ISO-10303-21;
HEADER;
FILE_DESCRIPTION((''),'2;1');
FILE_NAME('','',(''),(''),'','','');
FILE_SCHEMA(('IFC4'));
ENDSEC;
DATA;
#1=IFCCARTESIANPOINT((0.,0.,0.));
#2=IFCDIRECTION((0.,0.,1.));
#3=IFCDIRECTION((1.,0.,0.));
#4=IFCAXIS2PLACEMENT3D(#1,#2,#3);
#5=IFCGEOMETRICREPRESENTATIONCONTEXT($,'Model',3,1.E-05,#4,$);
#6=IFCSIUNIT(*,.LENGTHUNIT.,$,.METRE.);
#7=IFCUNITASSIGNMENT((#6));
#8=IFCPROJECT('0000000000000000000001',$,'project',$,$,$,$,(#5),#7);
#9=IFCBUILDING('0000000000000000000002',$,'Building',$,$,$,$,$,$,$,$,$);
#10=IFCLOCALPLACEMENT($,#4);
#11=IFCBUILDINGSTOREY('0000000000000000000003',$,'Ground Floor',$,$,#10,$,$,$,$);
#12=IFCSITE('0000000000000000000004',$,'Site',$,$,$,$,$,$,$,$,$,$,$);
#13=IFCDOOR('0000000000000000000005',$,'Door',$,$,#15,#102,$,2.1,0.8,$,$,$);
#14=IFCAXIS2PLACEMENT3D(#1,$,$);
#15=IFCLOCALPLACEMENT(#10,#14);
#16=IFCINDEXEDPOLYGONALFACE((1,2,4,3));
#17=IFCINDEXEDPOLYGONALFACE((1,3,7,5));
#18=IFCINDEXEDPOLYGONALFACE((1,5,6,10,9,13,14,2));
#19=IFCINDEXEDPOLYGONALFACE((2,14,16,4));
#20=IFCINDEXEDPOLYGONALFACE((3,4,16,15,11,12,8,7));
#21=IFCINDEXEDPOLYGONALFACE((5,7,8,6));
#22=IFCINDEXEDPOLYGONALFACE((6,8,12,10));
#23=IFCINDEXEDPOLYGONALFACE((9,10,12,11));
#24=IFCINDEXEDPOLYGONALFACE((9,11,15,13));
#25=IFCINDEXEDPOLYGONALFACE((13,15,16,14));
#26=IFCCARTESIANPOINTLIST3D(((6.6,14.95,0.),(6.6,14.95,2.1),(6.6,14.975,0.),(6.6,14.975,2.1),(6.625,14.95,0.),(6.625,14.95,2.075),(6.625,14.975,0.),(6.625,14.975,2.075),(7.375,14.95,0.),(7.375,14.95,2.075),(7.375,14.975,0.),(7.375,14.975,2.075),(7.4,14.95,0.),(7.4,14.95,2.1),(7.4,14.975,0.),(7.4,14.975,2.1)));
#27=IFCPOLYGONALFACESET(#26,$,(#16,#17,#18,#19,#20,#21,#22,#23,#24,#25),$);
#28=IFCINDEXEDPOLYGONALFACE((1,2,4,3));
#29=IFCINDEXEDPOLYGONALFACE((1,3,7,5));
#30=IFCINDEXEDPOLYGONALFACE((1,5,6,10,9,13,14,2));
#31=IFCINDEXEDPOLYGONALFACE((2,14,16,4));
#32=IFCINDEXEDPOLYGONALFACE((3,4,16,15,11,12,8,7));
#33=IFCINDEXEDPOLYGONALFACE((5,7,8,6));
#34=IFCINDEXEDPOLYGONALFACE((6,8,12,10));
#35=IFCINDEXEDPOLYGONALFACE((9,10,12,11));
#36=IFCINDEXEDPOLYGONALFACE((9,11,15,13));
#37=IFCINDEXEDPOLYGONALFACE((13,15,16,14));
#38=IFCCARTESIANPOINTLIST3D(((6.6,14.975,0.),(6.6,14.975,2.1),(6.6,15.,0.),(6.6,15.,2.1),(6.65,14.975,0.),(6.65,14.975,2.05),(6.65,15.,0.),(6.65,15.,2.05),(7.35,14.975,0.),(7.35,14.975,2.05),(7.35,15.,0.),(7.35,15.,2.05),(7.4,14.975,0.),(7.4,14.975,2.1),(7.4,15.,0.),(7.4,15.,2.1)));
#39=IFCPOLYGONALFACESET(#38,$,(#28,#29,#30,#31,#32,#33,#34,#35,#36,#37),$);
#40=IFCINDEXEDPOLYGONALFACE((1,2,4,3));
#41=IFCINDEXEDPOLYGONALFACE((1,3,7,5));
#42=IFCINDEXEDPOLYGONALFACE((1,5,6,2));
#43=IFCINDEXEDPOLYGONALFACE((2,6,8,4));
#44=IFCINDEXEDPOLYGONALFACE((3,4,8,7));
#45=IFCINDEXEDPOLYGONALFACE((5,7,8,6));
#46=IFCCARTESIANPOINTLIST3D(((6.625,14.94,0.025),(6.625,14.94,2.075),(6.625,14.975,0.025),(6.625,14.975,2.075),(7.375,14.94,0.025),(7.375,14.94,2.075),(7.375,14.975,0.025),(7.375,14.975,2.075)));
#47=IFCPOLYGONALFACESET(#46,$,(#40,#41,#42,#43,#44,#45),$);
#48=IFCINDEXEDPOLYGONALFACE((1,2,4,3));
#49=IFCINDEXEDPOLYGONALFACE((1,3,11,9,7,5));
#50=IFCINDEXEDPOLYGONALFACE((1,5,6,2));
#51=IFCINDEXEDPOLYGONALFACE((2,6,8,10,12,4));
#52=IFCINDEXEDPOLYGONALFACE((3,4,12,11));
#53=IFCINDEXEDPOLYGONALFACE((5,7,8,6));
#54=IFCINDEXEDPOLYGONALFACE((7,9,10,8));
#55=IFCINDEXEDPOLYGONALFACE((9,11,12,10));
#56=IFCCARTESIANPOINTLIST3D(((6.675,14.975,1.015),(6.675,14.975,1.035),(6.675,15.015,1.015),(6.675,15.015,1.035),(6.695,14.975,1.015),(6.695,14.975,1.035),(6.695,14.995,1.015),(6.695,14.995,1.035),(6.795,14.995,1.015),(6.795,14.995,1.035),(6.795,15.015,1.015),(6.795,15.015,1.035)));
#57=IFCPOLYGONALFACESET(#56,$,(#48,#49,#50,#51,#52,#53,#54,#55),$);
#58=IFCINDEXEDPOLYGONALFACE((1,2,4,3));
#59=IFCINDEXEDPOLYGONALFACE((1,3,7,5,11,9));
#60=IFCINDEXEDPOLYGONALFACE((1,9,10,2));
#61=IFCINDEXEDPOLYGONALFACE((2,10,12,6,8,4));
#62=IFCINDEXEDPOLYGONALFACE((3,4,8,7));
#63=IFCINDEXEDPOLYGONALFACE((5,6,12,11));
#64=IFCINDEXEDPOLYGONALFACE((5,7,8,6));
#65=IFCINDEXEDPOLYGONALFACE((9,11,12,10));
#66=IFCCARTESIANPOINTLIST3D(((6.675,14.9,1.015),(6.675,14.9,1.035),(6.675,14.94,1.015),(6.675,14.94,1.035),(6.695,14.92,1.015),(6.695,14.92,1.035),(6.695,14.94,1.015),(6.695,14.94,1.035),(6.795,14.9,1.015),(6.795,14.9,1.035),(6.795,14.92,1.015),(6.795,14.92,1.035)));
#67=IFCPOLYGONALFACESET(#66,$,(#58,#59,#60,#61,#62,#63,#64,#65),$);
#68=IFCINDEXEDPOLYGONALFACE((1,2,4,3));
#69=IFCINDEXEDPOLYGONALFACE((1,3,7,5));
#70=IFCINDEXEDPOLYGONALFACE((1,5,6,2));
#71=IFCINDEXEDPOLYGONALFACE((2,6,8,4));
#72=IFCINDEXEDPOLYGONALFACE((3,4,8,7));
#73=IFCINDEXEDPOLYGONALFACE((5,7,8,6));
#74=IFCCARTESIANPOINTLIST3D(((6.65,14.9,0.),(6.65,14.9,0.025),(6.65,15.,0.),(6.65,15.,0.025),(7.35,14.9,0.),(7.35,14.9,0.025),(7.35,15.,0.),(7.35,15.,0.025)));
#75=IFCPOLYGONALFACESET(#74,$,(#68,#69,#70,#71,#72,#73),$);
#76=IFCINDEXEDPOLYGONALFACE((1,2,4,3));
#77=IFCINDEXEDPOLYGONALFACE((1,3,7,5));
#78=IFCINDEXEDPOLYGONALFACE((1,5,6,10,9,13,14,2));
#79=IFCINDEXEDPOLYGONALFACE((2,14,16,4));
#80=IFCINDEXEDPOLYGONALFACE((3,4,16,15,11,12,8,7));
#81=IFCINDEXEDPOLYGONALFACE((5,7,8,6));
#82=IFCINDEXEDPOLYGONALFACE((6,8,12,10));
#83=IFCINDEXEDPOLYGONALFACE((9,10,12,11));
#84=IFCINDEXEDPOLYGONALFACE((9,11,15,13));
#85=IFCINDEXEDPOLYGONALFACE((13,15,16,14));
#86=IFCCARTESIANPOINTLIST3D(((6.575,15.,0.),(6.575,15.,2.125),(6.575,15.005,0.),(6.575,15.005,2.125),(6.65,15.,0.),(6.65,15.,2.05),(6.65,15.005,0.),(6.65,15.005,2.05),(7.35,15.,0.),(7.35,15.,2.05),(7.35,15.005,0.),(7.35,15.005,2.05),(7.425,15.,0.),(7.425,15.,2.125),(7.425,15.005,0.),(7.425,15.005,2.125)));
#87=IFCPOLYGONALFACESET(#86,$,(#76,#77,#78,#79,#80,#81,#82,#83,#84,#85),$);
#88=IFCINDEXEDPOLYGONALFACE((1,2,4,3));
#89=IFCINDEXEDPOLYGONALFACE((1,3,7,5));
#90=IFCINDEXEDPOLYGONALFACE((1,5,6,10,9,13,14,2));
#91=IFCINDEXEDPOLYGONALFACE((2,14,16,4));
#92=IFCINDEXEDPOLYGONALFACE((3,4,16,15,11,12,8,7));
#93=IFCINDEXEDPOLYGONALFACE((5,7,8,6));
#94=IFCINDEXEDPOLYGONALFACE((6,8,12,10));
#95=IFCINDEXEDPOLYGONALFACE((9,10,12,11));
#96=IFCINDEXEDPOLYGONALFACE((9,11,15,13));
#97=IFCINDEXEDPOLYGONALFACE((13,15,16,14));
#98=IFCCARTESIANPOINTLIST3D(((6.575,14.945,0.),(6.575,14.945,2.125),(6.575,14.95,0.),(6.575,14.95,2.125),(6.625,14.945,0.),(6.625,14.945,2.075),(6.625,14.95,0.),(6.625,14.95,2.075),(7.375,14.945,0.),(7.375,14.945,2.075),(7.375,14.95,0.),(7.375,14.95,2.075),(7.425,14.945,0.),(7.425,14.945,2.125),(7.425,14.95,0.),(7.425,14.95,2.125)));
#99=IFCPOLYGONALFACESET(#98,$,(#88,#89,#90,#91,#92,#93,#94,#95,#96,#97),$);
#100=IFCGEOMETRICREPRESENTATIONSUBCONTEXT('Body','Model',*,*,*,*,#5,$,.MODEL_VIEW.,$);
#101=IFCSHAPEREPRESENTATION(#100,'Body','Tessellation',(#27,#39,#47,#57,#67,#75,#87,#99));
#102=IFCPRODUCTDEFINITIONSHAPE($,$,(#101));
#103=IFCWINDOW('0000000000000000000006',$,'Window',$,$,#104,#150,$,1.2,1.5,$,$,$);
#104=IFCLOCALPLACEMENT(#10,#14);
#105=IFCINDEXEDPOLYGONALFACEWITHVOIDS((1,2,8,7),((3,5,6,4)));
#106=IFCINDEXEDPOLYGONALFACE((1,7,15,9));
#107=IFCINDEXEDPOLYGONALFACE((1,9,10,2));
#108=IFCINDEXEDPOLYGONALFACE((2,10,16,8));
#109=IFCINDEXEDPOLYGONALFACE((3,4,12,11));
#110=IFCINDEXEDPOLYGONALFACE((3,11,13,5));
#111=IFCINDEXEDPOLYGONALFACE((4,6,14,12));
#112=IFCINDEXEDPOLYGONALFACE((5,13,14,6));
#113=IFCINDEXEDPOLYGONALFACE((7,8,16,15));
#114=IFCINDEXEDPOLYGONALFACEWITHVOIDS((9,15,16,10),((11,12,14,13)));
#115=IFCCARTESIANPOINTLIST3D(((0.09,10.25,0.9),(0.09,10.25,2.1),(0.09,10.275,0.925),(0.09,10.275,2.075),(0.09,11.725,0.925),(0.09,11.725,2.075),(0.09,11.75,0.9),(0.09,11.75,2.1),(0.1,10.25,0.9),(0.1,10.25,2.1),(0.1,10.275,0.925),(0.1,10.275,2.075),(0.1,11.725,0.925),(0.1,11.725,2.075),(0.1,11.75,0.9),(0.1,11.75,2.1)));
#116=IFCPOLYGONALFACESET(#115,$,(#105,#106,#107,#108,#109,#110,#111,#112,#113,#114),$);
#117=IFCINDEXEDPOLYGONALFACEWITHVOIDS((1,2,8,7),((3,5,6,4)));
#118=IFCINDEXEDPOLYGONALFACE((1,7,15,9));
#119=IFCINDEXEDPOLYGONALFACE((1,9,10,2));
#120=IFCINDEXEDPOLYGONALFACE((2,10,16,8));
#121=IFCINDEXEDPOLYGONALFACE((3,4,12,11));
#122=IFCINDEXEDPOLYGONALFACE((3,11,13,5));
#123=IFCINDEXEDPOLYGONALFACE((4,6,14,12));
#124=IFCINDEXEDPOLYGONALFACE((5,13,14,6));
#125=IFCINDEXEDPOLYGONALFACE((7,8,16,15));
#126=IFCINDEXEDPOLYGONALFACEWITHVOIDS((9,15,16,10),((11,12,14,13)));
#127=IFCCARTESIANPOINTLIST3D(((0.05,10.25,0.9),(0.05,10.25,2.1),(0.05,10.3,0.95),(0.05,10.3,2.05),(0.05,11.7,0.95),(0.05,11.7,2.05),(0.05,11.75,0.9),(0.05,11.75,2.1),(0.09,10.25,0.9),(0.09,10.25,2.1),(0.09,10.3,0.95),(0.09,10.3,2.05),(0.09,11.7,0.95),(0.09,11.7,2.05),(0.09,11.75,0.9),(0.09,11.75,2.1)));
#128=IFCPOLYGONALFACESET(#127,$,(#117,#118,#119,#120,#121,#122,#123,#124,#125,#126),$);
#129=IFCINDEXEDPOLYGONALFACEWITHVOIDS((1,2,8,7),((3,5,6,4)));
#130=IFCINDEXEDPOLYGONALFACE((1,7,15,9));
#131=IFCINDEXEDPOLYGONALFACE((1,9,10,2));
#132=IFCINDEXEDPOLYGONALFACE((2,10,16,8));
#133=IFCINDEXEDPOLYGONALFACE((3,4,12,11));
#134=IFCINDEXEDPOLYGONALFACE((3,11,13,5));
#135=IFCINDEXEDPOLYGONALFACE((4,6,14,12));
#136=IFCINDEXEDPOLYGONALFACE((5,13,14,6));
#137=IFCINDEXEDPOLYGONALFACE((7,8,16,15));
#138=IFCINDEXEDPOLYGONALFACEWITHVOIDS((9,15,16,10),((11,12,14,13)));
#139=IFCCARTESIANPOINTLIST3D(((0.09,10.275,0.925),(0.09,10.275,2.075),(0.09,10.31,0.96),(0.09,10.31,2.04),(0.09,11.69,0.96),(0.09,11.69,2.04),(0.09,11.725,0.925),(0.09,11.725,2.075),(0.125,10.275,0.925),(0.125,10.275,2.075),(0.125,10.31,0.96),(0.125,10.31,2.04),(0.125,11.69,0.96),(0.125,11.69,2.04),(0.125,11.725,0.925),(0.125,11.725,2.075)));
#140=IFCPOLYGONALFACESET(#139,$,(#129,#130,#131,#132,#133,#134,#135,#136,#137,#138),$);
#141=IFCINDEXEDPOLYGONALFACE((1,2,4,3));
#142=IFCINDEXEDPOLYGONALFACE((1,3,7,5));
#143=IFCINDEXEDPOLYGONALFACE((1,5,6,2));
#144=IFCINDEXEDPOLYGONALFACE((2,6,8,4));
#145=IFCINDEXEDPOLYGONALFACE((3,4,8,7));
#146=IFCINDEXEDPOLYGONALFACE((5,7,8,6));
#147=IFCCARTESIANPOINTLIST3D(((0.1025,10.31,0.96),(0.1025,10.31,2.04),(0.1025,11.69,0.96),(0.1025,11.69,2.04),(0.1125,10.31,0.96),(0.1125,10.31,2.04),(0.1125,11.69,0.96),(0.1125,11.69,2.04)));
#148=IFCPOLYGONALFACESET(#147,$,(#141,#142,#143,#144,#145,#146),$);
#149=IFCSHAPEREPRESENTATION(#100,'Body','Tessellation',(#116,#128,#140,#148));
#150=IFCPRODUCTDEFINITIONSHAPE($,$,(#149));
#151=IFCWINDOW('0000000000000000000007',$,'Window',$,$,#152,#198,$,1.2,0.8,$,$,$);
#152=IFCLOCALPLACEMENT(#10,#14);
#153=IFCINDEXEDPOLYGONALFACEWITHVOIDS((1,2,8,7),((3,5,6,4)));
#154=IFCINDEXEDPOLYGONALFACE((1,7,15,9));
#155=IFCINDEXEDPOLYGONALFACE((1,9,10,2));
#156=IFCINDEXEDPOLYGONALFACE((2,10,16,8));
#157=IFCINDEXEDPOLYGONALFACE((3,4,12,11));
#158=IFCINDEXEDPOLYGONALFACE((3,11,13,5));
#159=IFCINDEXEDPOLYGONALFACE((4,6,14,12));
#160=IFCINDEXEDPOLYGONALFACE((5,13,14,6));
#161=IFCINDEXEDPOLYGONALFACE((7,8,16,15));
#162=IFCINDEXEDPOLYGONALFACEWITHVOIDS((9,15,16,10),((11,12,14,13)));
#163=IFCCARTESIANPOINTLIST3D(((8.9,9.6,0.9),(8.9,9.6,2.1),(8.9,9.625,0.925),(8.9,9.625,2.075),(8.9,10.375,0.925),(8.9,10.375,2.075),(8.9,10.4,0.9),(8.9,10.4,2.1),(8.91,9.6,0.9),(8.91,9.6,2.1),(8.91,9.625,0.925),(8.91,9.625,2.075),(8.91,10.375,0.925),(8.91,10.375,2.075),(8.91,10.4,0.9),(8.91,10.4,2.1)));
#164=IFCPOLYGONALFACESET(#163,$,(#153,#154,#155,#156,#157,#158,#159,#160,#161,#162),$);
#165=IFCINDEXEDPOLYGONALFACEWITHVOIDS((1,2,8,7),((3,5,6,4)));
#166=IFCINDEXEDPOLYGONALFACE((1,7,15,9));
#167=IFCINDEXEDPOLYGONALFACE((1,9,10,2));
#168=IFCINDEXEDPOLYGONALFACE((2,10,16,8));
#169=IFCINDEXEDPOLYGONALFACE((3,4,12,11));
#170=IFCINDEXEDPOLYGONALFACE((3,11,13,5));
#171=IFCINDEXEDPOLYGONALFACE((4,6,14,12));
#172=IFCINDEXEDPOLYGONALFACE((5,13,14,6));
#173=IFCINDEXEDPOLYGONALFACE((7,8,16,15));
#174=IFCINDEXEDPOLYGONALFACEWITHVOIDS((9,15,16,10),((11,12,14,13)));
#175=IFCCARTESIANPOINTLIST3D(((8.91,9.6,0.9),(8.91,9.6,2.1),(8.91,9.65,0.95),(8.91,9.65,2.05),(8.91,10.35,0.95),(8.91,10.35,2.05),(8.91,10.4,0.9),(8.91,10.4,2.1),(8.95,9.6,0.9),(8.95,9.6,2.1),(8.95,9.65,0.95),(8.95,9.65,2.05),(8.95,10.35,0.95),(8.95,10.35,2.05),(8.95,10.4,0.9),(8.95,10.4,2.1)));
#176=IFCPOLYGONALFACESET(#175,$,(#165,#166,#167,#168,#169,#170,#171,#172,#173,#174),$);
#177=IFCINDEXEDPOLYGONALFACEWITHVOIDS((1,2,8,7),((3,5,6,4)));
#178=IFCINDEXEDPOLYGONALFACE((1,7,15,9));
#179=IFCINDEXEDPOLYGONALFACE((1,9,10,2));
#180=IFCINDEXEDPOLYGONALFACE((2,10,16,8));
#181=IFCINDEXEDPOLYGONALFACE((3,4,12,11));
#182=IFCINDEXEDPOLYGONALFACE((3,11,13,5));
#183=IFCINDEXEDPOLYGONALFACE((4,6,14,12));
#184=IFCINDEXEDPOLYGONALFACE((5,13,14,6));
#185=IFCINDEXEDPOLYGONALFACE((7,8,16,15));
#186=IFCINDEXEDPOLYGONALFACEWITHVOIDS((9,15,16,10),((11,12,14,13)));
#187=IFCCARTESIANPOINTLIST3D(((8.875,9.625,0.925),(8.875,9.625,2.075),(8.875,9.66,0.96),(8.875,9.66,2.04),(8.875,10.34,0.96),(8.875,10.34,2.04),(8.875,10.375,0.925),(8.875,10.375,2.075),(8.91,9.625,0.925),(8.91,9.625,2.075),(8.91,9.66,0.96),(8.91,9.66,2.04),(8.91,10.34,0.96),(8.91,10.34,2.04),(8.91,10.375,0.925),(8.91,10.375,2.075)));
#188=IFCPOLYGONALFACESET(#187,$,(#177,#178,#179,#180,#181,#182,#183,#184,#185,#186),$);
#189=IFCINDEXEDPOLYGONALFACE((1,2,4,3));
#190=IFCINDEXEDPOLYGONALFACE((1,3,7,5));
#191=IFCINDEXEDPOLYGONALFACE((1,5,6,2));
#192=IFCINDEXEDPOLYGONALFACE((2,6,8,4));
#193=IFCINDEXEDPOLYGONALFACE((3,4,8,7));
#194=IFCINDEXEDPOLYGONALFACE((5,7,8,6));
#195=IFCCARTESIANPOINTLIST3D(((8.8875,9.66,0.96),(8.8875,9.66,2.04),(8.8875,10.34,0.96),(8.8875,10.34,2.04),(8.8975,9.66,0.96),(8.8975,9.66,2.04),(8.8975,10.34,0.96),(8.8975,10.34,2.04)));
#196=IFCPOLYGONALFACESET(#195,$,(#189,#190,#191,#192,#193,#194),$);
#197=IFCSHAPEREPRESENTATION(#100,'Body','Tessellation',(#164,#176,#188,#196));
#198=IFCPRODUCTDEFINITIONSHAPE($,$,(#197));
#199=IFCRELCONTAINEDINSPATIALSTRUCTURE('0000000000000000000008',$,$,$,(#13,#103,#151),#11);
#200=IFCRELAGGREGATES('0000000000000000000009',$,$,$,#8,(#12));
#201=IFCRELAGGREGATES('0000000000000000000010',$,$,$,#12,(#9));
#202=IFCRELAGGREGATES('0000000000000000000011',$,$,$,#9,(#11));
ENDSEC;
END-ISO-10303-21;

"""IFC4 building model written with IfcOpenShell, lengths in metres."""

from ifc_helpers import new_model, si_unit, frame, origin_with_axes, place, context, subcontext, project, spatial, line, indexed_curve, outline, extrude, element, save


model = new_model("IFC4")

# Units and contexts
model_context = context("Model", 3, precision=1e-05, world=origin_with_axes())
body_context = subcontext(model_context, "Body", "Model", "MODEL_VIEW")
ifc_project = project(units=[si_unit("LENGTHUNIT", "METRE")], contexts=[model_context])

# Site, building, storey
site = spatial("IfcSite", under=ifc_project, Name="Site")
building = spatial("IfcBuilding", under=site, Name="Building")
storey_placement = place(None, origin_with_axes())
storey = spatial("IfcBuildingStorey", under=building, at=storey_placement, Name="Ground Floor")

# Door
door_1_placement = place(storey_placement, frame((7.4, 15.0, 0.0), z_axis=(0.0, 0.0, 1.0), x_axis=(-1.0, 0.0, 0.0)))
element("IfcDoor", 1, at=door_1_placement, inside=storey, Name="Door", OverallHeight=2.1, OverallWidth=0.8, context=body_context, shape_type="SweptSolid", body=[
    extrude(outline(indexed_curve([(0.0, 0.0), (0.0, 2.1), (0.8, 2.1), (0.8, 0.0), (0.775, 0.0), (0.775, 2.075), (0.025, 2.075), (0.025, 0.0)], segments=[line(1, 2, 3, 4, 5, 6, 7, 8, 1)])), frame((0.0, 0.025, 0.0), z_axis=(0.0, -1.0, 0.0), x_axis=(1.0, 0.0, 0.0)), (0.0, 0.0, -1.0), 0.025),
    extrude(outline(indexed_curve([(0.0, 0.0), (0.0, 2.1), (0.8, 2.1), (0.8, 0.0), (0.75, 0.0), (0.75, 2.05), (0.05, 2.05), (0.05, 0.0)], segments=[line(1, 2, 3, 4, 5, 6, 7, 8, 1)])), frame((0.0, 0.0, 0.0), z_axis=(0.0, -1.0, 0.0), x_axis=(1.0, 0.0, 0.0)), (0.0, 0.0, -1.0), 0.025),
    extrude(outline(indexed_curve([(0.0, 0.0), (0.75, 0.0), (0.75, 0.035), (0.0, 0.035)], segments=[line(1, 2, 3, 4, 1)])), frame((0.025, 0.025, 0.025), z_axis=(0.0, 0.0, 1.0), x_axis=(1.0, 0.0, 0.0)), (0.0, 0.0, 1.0), 2.05),
    extrude(outline(indexed_curve([(0.0, 0.0), (0.0, -0.04), (-0.12, -0.04), (-0.12, -0.02), (-0.02, -0.02), (-0.02, 0.0)], segments=[line(1, 2, 3, 4, 5, 6, 1)])), frame((0.725, 0.025, 1.015), z_axis=(0.0, 0.0, 1.0), x_axis=(1.0, 0.0, 0.0)), (0.0, 0.0, 1.0), 0.02),
    extrude(outline(indexed_curve([(0.0, 0.0), (0.0, 0.04), (-0.12, 0.04), (-0.12, 0.02), (-0.02, 0.02), (-0.02, 0.0)], segments=[line(1, 2, 3, 4, 5, 6, 1)])), frame((0.725, 0.06, 1.015), z_axis=(0.0, 0.0, 1.0), x_axis=(1.0, 0.0, 0.0)), (0.0, 0.0, 1.0), 0.02),
    extrude(outline(indexed_curve([(0.0, 0.0), (0.7, 0.0), (0.7, 0.1), (0.0, 0.1)], segments=[line(1, 2, 3, 4, 1)])), frame((0.05, 0.0, 0.0), z_axis=(0.0, 0.0, 1.0), x_axis=(1.0, 0.0, 0.0)), (0.0, 0.0, 1.0), 0.025),
    extrude(outline(indexed_curve([(0.0, 0.0), (0.0, 2.125), (0.85, 2.125), (0.85, 0.0), (0.775, 0.0), (0.775, 2.05), (0.075, 2.05), (0.075, 0.0)], segments=[line(1, 2, 3, 4, 5, 6, 7, 8, 1)])), frame((-0.025, -0.005, 0.0), z_axis=(0.0, -1.0, 0.0), x_axis=(1.0, 0.0, 0.0)), (0.0, 0.0, -1.0), 0.005),
    extrude(outline(indexed_curve([(0.0, 0.0), (0.0, 2.125), (0.85, 2.125), (0.85, 0.0), (0.8, 0.0), (0.8, 2.075), (0.05, 2.075), (0.05, 0.0)], segments=[line(1, 2, 3, 4, 5, 6, 7, 8, 1)])), frame((-0.025, 0.05, 0.0), z_axis=(0.0, -1.0, 0.0), x_axis=(1.0, 0.0, 0.0)), (0.0, 0.0, -1.0), 0.005),
])

# Windows
window_1_placement = place(storey_placement, frame((0.0, 11.75, 0.9), z_axis=(0.0, 0.0, 1.0), x_axis=(0.0, -1.0, 0.0)))
element("IfcWindow", 2, at=window_1_placement, inside=storey, Name="Window", OverallHeight=1.2, OverallWidth=1.5, context=body_context, shape_type="SweptSolid", body=[
    extrude(outline(indexed_curve([(0.0, 0.0), (1.5, 0.0), (1.5, 1.2), (0.0, 1.2)], segments=[line(1, 2, 3, 4, 1)]), holes=[indexed_curve([(0.025, 0.025), (1.475, 0.025), (1.475, 1.175), (0.025, 1.175)], segments=[line(1, 2, 3, 4, 1)])]), frame((0.0, 0.09, 0.0), z_axis=(0.0, -1.0, 0.0), x_axis=(1.0, 0.0, 0.0)), (0.0, 0.0, -1.0), 0.01),
    extrude(outline(indexed_curve([(0.0, 0.0), (1.5, 0.0), (1.5, 1.2), (0.0, 1.2)], segments=[line(1, 2, 3, 4, 1)]), holes=[indexed_curve([(0.05, 0.05), (1.45, 0.05), (1.45, 1.15), (0.05, 1.15)], segments=[line(1, 2, 3, 4, 1)])]), frame((0.0, 0.05, 0.0), z_axis=(0.0, -1.0, 0.0), x_axis=(1.0, 0.0, 0.0)), (0.0, 0.0, -1.0), 0.04),
    extrude(outline(indexed_curve([(0.0, 0.0), (1.45, 0.0), (1.45, 1.15), (0.0, 1.15)], segments=[line(1, 2, 3, 4, 1)]), holes=[indexed_curve([(0.035, 0.035), (1.415, 0.035), (1.415, 1.115), (0.035, 1.115)], segments=[line(1, 2, 3, 4, 1)])]), frame((0.025, 0.09, 0.025), z_axis=(0.0, -1.0, 0.0), x_axis=(1.0, 0.0, 0.0)), (0.0, 0.0, -1.0), 0.035),
    extrude(outline(indexed_curve([(0.035, 0.035), (1.415, 0.035), (1.415, 1.115), (0.035, 1.115)], segments=[line(1, 2, 3, 4, 1)])), frame((0.025, 0.1025, 0.025), z_axis=(0.0, -1.0, 0.0), x_axis=(1.0, 0.0, 0.0)), (0.0, 0.0, -1.0), 0.01),
])
window_2_placement = place(storey_placement, frame((9.0, 9.6, 0.9), z_axis=(0.0, 0.0, 1.0), x_axis=(0.0, 1.0, 0.0)))
element("IfcWindow", 3, at=window_2_placement, inside=storey, Name="Window", OverallHeight=1.2, OverallWidth=0.8, context=body_context, shape_type="SweptSolid", body=[
    extrude(outline(indexed_curve([(0.0, 0.0), (0.8, 0.0), (0.8, 1.2), (0.0, 1.2)], segments=[line(1, 2, 3, 4, 1)]), holes=[indexed_curve([(0.025, 0.025), (0.775, 0.025), (0.775, 1.175), (0.025, 1.175)], segments=[line(1, 2, 3, 4, 1)])]), frame((0.0, 0.09, 0.0), z_axis=(0.0, -1.0, 0.0), x_axis=(1.0, 0.0, 0.0)), (0.0, 0.0, -1.0), 0.01),
    extrude(outline(indexed_curve([(0.0, 0.0), (0.8, 0.0), (0.8, 1.2), (0.0, 1.2)], segments=[line(1, 2, 3, 4, 1)]), holes=[indexed_curve([(0.05, 0.05), (0.75, 0.05), (0.75, 1.15), (0.05, 1.15)], segments=[line(1, 2, 3, 4, 1)])]), frame((0.0, 0.05, 0.0), z_axis=(0.0, -1.0, 0.0), x_axis=(1.0, 0.0, 0.0)), (0.0, 0.0, -1.0), 0.04),
    extrude(outline(indexed_curve([(0.0, 0.0), (0.75, 0.0), (0.75, 1.15), (0.0, 1.15)], segments=[line(1, 2, 3, 4, 1)]), holes=[indexed_curve([(0.035, 0.035), (0.715, 0.035), (0.715, 1.115), (0.035, 1.115)], segments=[line(1, 2, 3, 4, 1)])]), frame((0.025, 0.09, 0.025), z_axis=(0.0, -1.0, 0.0), x_axis=(1.0, 0.0, 0.0)), (0.0, 0.0, -1.0), 0.035),
    extrude(outline(indexed_curve([(0.035, 0.035), (0.715, 0.035), (0.715, 1.115), (0.035, 1.115)], segments=[line(1, 2, 3, 4, 1)])), frame((0.025, 0.1025, 0.025), z_axis=(0.0, -1.0, 0.0), x_axis=(1.0, 0.0, 0.0)), (0.0, 0.0, -1.0), 0.01),
])

save(model, "model.ifc")
